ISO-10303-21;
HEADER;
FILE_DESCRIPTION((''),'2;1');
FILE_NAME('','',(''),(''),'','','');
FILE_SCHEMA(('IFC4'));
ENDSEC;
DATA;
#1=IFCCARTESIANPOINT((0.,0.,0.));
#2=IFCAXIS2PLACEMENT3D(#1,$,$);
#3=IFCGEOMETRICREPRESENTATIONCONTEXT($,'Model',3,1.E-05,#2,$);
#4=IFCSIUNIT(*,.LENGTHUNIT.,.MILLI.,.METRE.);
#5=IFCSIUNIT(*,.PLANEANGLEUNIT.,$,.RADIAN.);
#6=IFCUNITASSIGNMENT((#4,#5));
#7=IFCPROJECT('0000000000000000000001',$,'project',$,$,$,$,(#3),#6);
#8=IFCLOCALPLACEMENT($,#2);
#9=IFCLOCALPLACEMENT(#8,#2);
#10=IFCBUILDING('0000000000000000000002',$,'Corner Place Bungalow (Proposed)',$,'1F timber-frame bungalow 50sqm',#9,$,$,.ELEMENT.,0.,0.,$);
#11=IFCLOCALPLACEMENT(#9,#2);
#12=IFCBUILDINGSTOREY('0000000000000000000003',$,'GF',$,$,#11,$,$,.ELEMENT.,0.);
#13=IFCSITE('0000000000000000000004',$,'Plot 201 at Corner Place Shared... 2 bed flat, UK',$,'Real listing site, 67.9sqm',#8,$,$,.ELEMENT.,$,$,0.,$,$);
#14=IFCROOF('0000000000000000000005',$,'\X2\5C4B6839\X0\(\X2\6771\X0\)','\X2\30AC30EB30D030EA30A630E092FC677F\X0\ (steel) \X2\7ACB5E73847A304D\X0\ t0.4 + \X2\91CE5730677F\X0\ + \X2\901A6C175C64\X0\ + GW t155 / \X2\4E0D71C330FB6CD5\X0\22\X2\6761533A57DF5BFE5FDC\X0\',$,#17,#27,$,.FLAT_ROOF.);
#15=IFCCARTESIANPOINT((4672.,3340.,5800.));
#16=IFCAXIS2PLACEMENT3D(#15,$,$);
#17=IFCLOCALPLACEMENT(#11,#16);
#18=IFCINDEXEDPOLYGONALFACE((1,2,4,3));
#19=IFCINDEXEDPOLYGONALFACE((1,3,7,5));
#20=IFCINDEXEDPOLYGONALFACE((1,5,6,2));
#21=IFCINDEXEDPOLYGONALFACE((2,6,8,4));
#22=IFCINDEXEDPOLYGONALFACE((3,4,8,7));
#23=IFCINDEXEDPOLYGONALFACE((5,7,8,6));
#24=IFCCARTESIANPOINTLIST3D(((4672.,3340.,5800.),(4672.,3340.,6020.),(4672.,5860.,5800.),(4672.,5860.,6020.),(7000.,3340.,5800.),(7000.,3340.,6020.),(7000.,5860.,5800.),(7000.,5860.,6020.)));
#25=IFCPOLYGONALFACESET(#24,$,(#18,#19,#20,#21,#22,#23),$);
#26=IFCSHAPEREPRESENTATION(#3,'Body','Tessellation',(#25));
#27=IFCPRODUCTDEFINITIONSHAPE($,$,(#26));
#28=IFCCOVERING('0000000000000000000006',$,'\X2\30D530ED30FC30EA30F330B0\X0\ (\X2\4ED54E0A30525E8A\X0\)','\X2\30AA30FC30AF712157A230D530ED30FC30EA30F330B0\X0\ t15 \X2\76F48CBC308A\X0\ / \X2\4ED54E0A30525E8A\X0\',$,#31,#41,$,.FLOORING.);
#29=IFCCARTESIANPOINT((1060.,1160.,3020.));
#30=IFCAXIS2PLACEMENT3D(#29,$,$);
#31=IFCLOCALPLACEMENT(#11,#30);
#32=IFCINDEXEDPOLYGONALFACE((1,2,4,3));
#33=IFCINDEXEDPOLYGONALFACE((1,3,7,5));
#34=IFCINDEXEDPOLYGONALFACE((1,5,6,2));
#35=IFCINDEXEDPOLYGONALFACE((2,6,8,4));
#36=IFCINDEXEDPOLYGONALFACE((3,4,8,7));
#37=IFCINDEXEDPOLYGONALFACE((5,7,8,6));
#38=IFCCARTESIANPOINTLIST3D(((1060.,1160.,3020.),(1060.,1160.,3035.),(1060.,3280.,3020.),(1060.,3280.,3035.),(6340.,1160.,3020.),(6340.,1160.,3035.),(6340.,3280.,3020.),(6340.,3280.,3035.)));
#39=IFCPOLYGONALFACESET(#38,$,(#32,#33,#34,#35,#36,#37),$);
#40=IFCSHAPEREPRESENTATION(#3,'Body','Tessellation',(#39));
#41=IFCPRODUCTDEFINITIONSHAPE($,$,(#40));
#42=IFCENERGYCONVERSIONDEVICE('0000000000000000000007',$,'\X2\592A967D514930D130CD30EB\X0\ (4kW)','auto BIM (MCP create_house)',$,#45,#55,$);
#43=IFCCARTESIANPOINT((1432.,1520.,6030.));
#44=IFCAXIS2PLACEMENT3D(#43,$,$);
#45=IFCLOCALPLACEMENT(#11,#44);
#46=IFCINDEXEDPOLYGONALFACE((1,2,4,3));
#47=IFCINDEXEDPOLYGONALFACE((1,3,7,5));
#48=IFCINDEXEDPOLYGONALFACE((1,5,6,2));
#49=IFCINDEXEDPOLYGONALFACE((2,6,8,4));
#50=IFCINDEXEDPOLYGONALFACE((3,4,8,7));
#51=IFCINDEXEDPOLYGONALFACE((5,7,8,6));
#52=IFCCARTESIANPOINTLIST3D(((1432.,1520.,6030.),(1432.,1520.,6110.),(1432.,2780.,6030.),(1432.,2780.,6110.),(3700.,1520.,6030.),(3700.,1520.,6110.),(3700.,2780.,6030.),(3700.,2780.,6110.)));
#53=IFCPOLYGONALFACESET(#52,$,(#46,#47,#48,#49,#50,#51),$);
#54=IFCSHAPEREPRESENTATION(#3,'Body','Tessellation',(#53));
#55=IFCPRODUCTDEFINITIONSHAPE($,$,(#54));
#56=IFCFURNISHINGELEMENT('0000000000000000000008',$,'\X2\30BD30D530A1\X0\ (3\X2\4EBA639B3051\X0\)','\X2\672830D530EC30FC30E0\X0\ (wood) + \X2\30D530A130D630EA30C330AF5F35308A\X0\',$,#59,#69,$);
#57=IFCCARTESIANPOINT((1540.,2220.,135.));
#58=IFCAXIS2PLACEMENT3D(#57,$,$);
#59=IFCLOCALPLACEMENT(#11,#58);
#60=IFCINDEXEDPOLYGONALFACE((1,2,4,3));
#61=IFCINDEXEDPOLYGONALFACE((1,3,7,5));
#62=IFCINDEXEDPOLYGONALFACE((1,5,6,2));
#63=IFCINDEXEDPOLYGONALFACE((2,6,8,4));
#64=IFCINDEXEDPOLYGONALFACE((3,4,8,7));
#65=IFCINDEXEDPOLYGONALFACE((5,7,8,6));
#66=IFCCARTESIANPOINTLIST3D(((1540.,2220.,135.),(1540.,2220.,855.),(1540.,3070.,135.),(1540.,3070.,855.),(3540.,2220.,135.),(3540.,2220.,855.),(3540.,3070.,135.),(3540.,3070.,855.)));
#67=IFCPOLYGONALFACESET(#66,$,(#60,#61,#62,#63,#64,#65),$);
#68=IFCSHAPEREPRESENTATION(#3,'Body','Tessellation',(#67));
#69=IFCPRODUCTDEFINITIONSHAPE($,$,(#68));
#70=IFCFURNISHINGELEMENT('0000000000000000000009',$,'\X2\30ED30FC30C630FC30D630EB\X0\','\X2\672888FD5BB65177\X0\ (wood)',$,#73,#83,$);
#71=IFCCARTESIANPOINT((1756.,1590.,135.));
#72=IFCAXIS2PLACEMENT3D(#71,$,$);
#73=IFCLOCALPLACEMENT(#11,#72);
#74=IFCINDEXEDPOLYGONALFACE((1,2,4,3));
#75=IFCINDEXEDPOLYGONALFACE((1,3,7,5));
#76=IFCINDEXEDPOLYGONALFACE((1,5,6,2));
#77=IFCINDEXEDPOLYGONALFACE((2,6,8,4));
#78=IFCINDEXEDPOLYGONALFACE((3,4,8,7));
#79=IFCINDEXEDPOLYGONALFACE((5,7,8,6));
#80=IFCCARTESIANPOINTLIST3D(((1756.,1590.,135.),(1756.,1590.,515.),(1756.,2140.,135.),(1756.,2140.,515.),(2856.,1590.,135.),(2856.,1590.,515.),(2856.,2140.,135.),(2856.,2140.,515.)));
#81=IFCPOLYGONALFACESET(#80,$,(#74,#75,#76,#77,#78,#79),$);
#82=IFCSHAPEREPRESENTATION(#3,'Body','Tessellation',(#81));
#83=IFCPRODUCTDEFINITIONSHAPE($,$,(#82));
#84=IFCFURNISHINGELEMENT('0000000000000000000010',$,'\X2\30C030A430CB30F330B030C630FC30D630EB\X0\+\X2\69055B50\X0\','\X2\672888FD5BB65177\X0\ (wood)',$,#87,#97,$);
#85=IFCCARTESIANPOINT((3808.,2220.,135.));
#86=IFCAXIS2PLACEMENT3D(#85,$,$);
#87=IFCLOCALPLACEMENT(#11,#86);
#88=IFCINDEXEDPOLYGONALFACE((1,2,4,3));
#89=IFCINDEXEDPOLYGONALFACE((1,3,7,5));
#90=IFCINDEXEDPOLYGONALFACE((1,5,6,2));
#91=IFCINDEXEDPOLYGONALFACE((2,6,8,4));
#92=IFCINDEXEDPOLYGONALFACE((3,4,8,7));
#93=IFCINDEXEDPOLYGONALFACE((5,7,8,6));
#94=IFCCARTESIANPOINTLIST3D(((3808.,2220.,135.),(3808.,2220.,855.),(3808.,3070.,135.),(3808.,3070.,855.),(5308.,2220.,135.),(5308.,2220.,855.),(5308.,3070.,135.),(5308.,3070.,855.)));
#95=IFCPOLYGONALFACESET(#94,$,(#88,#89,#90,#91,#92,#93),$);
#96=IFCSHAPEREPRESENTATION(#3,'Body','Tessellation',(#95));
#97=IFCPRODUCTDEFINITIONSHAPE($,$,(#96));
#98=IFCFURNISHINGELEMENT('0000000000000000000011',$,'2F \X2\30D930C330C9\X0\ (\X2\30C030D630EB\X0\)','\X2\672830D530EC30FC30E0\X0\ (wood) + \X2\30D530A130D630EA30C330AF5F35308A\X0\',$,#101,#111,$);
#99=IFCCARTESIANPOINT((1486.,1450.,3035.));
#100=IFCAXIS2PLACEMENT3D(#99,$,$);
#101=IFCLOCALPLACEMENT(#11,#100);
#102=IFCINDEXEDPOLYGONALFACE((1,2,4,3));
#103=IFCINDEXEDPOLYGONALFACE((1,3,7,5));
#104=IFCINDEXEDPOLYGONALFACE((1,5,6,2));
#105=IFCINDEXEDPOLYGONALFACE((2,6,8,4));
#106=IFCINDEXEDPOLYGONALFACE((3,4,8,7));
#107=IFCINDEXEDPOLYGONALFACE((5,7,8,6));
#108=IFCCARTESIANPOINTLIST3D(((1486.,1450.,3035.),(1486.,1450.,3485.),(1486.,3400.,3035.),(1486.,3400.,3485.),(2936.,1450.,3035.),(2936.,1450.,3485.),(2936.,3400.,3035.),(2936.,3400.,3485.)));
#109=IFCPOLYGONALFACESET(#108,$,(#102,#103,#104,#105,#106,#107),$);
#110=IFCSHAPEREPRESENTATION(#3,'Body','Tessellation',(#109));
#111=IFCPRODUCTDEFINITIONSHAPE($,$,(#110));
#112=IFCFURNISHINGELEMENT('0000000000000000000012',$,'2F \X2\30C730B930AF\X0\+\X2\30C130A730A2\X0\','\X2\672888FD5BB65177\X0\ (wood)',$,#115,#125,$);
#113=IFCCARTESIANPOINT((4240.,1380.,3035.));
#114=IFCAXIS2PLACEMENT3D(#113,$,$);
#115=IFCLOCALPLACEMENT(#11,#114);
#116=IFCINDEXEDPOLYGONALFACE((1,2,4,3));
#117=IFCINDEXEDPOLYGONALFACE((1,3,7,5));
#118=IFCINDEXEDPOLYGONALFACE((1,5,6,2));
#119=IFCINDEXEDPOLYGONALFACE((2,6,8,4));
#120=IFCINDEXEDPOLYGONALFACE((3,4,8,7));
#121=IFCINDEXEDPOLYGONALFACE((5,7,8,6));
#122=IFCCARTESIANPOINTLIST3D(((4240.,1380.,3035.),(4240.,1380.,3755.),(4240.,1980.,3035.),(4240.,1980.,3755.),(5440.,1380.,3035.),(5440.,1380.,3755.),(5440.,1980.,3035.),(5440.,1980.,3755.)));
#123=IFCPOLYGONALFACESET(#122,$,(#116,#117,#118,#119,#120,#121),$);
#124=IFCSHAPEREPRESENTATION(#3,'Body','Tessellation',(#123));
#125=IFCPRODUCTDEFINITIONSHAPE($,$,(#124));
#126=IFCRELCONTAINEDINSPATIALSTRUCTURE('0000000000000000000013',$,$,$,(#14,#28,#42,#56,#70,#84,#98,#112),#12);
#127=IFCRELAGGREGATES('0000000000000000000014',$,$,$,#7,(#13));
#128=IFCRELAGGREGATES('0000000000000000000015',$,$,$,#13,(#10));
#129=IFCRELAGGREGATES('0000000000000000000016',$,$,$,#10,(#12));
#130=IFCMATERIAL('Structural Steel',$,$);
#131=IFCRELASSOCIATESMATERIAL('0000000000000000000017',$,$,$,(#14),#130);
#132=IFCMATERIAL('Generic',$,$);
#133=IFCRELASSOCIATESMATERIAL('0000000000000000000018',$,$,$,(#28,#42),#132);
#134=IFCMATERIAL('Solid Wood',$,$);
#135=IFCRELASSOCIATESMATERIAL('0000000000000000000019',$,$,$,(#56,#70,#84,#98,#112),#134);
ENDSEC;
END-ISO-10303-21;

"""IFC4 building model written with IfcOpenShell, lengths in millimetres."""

from ifc_helpers import new_model, si_unit, frame, frame_2d, origin, place, context, project, spatial, rectangle, extrude, material, element, save


model = new_model("IFC4")

# Units and contexts
model_context = context("Model", 3, precision=1e-05, world=origin())
ifc_project = project(units=[si_unit("LENGTHUNIT", "METRE", prefix="MILLI"), si_unit("PLANEANGLEUNIT", "RADIAN")], contexts=[model_context])

# Site, building, storey
site_placement = place(None, origin())
site = spatial("IfcSite", under=ifc_project, at=site_placement, Name="Plot 201 at Corner Place Shared... 2 bed flat, UK", ObjectType="Real listing site, 67.9sqm", CompositionType="ELEMENT", RefElevation=0.0)
building_placement = place(site_placement, origin())
building = spatial("IfcBuilding", under=site, at=building_placement, Name="Corner Place Bungalow (Proposed)", ObjectType="1F timber-frame bungalow 50sqm", CompositionType="ELEMENT", ElevationOfRefHeight=0.0, ElevationOfTerrain=0.0)
storey_placement = place(building_placement, origin())
storey = spatial("IfcBuildingStorey", under=building, at=storey_placement, Name="GF", CompositionType="ELEMENT", Elevation=0.0)

# Shared definitions
ifc_material_1 = material(Name="Solid Wood")

# Roof
ifc_material_2 = material(Name="Structural Steel")
roof_1_placement = place(storey_placement, frame((4672.0, 3340.0, 5800.0)))
element("IfcRoof", 1, at=roof_1_placement, inside=storey, material=ifc_material_2, Name="屋根(東)", Description="ガルバリウム鋼板 (steel) 立平葺き t0.4 + 野地板 + 通気層 + GW t155 / 不燃・法22条区域対応", PredefinedType="FLAT_ROOF", context=model_context, shape_type="SweptSolid", body=[
    extrude(rectangle(XDim=2328.0, YDim=2520.0, at=frame_2d((1164.0, 1260.0))), frame((4672.0, 3340.0, 5800.0)), (0.0, 0.0, 1.0), 220.0),
])

# Covering
ifc_material_3 = material(Name="Generic")
covering_placement = place(storey_placement, frame((1060.0, 1160.0, 3020.0)))
element("IfcCovering", 2, at=covering_placement, inside=storey, material=ifc_material_3, Name="フローリング (仕上げ床)", Description="オーク無垢フローリング t15 直貼り / 仕上げ床", PredefinedType="FLOORING", context=model_context, shape_type="SweptSolid", body=[
    extrude(rectangle(XDim=5280.0, YDim=2120.0, at=frame_2d((2640.0, 1060.0))), frame((1060.0, 1160.0, 3020.0)), (0.0, 0.0, 1.0), 15.0),
])

# Energy conversion device
energy_conversion_device_placement = place(storey_placement, frame((1432.0, 1520.0, 6030.0)))
element("IfcEnergyConversionDevice", 3, at=energy_conversion_device_placement, inside=storey, material=ifc_material_3, Name="太陽光パネル (4kW)", Description="auto BIM (MCP create_house)", context=model_context, shape_type="SweptSolid", body=[
    extrude(rectangle(XDim=2268.0, YDim=1260.0, at=frame_2d((1134.0, 630.0))), frame((1432.0, 1520.0, 6030.0)), (0.0, 0.0, 1.0), 80.0),
])

# Furnishing elements
furnishing_1_placement = place(storey_placement, frame((1540.0, 2220.0, 135.0)))
element("IfcFurnishingElement", 4, at=furnishing_1_placement, inside=storey, material=ifc_material_1, Name="ソファ (3人掛け)", Description="木フレーム (wood) + ファブリック張り", context=model_context, shape_type="SweptSolid", body=[
    extrude(rectangle(XDim=2000.0, YDim=850.0, at=frame_2d((1000.0, 425.0))), frame((1540.0, 2220.0, 135.0)), (0.0, 0.0, 1.0), 720.0),
])
furnishing_2_placement = place(storey_placement, frame((1756.0, 1590.0, 135.0)))
element("IfcFurnishingElement", 5, at=furnishing_2_placement, inside=storey, material=ifc_material_1, Name="ローテーブル", Description="木製家具 (wood)", context=model_context, shape_type="SweptSolid", body=[
    extrude(rectangle(XDim=1100.0, YDim=550.0, at=frame_2d((550.0, 275.0))), frame((1756.0, 1590.0, 135.0)), (0.0, 0.0, 1.0), 380.0),
])
furnishing_3_placement = place(storey_placement, frame((3808.0, 2220.0, 135.0)))
element("IfcFurnishingElement", 6, at=furnishing_3_placement, inside=storey, material=ifc_material_1, Name="ダイニングテーブル+椅子", Description="木製家具 (wood)", context=model_context, shape_type="SweptSolid", body=[
    extrude(rectangle(XDim=1500.0, YDim=850.0, at=frame_2d((750.0, 425.0))), frame((3808.0, 2220.0, 135.0)), (0.0, 0.0, 1.0), 720.0),
])
furnishing_4_placement = place(storey_placement, frame((1486.0, 1450.0, 3035.0)))
element("IfcFurnishingElement", 7, at=furnishing_4_placement, inside=storey, material=ifc_material_1, Name="2F ベッド (ダブル)", Description="木フレーム (wood) + ファブリック張り", context=model_context, shape_type="SweptSolid", body=[
    extrude(rectangle(XDim=1450.0, YDim=1950.0, at=frame_2d((725.0, 975.0))), frame((1486.0, 1450.0, 3035.0)), (0.0, 0.0, 1.0), 450.0),
])
furnishing_5_placement = place(storey_placement, frame((4240.0, 1380.0, 3035.0)))
element("IfcFurnishingElement", 8, at=furnishing_5_placement, inside=storey, material=ifc_material_1, Name="2F デスク+チェア", Description="木製家具 (wood)", context=model_context, shape_type="SweptSolid", body=[
    extrude(rectangle(XDim=1200.0, YDim=600.0, at=frame_2d((600.0, 300.0))), frame((4240.0, 1380.0, 3035.0)), (0.0, 0.0, 1.0), 720.0),
])

save(model, "model.ifc")
